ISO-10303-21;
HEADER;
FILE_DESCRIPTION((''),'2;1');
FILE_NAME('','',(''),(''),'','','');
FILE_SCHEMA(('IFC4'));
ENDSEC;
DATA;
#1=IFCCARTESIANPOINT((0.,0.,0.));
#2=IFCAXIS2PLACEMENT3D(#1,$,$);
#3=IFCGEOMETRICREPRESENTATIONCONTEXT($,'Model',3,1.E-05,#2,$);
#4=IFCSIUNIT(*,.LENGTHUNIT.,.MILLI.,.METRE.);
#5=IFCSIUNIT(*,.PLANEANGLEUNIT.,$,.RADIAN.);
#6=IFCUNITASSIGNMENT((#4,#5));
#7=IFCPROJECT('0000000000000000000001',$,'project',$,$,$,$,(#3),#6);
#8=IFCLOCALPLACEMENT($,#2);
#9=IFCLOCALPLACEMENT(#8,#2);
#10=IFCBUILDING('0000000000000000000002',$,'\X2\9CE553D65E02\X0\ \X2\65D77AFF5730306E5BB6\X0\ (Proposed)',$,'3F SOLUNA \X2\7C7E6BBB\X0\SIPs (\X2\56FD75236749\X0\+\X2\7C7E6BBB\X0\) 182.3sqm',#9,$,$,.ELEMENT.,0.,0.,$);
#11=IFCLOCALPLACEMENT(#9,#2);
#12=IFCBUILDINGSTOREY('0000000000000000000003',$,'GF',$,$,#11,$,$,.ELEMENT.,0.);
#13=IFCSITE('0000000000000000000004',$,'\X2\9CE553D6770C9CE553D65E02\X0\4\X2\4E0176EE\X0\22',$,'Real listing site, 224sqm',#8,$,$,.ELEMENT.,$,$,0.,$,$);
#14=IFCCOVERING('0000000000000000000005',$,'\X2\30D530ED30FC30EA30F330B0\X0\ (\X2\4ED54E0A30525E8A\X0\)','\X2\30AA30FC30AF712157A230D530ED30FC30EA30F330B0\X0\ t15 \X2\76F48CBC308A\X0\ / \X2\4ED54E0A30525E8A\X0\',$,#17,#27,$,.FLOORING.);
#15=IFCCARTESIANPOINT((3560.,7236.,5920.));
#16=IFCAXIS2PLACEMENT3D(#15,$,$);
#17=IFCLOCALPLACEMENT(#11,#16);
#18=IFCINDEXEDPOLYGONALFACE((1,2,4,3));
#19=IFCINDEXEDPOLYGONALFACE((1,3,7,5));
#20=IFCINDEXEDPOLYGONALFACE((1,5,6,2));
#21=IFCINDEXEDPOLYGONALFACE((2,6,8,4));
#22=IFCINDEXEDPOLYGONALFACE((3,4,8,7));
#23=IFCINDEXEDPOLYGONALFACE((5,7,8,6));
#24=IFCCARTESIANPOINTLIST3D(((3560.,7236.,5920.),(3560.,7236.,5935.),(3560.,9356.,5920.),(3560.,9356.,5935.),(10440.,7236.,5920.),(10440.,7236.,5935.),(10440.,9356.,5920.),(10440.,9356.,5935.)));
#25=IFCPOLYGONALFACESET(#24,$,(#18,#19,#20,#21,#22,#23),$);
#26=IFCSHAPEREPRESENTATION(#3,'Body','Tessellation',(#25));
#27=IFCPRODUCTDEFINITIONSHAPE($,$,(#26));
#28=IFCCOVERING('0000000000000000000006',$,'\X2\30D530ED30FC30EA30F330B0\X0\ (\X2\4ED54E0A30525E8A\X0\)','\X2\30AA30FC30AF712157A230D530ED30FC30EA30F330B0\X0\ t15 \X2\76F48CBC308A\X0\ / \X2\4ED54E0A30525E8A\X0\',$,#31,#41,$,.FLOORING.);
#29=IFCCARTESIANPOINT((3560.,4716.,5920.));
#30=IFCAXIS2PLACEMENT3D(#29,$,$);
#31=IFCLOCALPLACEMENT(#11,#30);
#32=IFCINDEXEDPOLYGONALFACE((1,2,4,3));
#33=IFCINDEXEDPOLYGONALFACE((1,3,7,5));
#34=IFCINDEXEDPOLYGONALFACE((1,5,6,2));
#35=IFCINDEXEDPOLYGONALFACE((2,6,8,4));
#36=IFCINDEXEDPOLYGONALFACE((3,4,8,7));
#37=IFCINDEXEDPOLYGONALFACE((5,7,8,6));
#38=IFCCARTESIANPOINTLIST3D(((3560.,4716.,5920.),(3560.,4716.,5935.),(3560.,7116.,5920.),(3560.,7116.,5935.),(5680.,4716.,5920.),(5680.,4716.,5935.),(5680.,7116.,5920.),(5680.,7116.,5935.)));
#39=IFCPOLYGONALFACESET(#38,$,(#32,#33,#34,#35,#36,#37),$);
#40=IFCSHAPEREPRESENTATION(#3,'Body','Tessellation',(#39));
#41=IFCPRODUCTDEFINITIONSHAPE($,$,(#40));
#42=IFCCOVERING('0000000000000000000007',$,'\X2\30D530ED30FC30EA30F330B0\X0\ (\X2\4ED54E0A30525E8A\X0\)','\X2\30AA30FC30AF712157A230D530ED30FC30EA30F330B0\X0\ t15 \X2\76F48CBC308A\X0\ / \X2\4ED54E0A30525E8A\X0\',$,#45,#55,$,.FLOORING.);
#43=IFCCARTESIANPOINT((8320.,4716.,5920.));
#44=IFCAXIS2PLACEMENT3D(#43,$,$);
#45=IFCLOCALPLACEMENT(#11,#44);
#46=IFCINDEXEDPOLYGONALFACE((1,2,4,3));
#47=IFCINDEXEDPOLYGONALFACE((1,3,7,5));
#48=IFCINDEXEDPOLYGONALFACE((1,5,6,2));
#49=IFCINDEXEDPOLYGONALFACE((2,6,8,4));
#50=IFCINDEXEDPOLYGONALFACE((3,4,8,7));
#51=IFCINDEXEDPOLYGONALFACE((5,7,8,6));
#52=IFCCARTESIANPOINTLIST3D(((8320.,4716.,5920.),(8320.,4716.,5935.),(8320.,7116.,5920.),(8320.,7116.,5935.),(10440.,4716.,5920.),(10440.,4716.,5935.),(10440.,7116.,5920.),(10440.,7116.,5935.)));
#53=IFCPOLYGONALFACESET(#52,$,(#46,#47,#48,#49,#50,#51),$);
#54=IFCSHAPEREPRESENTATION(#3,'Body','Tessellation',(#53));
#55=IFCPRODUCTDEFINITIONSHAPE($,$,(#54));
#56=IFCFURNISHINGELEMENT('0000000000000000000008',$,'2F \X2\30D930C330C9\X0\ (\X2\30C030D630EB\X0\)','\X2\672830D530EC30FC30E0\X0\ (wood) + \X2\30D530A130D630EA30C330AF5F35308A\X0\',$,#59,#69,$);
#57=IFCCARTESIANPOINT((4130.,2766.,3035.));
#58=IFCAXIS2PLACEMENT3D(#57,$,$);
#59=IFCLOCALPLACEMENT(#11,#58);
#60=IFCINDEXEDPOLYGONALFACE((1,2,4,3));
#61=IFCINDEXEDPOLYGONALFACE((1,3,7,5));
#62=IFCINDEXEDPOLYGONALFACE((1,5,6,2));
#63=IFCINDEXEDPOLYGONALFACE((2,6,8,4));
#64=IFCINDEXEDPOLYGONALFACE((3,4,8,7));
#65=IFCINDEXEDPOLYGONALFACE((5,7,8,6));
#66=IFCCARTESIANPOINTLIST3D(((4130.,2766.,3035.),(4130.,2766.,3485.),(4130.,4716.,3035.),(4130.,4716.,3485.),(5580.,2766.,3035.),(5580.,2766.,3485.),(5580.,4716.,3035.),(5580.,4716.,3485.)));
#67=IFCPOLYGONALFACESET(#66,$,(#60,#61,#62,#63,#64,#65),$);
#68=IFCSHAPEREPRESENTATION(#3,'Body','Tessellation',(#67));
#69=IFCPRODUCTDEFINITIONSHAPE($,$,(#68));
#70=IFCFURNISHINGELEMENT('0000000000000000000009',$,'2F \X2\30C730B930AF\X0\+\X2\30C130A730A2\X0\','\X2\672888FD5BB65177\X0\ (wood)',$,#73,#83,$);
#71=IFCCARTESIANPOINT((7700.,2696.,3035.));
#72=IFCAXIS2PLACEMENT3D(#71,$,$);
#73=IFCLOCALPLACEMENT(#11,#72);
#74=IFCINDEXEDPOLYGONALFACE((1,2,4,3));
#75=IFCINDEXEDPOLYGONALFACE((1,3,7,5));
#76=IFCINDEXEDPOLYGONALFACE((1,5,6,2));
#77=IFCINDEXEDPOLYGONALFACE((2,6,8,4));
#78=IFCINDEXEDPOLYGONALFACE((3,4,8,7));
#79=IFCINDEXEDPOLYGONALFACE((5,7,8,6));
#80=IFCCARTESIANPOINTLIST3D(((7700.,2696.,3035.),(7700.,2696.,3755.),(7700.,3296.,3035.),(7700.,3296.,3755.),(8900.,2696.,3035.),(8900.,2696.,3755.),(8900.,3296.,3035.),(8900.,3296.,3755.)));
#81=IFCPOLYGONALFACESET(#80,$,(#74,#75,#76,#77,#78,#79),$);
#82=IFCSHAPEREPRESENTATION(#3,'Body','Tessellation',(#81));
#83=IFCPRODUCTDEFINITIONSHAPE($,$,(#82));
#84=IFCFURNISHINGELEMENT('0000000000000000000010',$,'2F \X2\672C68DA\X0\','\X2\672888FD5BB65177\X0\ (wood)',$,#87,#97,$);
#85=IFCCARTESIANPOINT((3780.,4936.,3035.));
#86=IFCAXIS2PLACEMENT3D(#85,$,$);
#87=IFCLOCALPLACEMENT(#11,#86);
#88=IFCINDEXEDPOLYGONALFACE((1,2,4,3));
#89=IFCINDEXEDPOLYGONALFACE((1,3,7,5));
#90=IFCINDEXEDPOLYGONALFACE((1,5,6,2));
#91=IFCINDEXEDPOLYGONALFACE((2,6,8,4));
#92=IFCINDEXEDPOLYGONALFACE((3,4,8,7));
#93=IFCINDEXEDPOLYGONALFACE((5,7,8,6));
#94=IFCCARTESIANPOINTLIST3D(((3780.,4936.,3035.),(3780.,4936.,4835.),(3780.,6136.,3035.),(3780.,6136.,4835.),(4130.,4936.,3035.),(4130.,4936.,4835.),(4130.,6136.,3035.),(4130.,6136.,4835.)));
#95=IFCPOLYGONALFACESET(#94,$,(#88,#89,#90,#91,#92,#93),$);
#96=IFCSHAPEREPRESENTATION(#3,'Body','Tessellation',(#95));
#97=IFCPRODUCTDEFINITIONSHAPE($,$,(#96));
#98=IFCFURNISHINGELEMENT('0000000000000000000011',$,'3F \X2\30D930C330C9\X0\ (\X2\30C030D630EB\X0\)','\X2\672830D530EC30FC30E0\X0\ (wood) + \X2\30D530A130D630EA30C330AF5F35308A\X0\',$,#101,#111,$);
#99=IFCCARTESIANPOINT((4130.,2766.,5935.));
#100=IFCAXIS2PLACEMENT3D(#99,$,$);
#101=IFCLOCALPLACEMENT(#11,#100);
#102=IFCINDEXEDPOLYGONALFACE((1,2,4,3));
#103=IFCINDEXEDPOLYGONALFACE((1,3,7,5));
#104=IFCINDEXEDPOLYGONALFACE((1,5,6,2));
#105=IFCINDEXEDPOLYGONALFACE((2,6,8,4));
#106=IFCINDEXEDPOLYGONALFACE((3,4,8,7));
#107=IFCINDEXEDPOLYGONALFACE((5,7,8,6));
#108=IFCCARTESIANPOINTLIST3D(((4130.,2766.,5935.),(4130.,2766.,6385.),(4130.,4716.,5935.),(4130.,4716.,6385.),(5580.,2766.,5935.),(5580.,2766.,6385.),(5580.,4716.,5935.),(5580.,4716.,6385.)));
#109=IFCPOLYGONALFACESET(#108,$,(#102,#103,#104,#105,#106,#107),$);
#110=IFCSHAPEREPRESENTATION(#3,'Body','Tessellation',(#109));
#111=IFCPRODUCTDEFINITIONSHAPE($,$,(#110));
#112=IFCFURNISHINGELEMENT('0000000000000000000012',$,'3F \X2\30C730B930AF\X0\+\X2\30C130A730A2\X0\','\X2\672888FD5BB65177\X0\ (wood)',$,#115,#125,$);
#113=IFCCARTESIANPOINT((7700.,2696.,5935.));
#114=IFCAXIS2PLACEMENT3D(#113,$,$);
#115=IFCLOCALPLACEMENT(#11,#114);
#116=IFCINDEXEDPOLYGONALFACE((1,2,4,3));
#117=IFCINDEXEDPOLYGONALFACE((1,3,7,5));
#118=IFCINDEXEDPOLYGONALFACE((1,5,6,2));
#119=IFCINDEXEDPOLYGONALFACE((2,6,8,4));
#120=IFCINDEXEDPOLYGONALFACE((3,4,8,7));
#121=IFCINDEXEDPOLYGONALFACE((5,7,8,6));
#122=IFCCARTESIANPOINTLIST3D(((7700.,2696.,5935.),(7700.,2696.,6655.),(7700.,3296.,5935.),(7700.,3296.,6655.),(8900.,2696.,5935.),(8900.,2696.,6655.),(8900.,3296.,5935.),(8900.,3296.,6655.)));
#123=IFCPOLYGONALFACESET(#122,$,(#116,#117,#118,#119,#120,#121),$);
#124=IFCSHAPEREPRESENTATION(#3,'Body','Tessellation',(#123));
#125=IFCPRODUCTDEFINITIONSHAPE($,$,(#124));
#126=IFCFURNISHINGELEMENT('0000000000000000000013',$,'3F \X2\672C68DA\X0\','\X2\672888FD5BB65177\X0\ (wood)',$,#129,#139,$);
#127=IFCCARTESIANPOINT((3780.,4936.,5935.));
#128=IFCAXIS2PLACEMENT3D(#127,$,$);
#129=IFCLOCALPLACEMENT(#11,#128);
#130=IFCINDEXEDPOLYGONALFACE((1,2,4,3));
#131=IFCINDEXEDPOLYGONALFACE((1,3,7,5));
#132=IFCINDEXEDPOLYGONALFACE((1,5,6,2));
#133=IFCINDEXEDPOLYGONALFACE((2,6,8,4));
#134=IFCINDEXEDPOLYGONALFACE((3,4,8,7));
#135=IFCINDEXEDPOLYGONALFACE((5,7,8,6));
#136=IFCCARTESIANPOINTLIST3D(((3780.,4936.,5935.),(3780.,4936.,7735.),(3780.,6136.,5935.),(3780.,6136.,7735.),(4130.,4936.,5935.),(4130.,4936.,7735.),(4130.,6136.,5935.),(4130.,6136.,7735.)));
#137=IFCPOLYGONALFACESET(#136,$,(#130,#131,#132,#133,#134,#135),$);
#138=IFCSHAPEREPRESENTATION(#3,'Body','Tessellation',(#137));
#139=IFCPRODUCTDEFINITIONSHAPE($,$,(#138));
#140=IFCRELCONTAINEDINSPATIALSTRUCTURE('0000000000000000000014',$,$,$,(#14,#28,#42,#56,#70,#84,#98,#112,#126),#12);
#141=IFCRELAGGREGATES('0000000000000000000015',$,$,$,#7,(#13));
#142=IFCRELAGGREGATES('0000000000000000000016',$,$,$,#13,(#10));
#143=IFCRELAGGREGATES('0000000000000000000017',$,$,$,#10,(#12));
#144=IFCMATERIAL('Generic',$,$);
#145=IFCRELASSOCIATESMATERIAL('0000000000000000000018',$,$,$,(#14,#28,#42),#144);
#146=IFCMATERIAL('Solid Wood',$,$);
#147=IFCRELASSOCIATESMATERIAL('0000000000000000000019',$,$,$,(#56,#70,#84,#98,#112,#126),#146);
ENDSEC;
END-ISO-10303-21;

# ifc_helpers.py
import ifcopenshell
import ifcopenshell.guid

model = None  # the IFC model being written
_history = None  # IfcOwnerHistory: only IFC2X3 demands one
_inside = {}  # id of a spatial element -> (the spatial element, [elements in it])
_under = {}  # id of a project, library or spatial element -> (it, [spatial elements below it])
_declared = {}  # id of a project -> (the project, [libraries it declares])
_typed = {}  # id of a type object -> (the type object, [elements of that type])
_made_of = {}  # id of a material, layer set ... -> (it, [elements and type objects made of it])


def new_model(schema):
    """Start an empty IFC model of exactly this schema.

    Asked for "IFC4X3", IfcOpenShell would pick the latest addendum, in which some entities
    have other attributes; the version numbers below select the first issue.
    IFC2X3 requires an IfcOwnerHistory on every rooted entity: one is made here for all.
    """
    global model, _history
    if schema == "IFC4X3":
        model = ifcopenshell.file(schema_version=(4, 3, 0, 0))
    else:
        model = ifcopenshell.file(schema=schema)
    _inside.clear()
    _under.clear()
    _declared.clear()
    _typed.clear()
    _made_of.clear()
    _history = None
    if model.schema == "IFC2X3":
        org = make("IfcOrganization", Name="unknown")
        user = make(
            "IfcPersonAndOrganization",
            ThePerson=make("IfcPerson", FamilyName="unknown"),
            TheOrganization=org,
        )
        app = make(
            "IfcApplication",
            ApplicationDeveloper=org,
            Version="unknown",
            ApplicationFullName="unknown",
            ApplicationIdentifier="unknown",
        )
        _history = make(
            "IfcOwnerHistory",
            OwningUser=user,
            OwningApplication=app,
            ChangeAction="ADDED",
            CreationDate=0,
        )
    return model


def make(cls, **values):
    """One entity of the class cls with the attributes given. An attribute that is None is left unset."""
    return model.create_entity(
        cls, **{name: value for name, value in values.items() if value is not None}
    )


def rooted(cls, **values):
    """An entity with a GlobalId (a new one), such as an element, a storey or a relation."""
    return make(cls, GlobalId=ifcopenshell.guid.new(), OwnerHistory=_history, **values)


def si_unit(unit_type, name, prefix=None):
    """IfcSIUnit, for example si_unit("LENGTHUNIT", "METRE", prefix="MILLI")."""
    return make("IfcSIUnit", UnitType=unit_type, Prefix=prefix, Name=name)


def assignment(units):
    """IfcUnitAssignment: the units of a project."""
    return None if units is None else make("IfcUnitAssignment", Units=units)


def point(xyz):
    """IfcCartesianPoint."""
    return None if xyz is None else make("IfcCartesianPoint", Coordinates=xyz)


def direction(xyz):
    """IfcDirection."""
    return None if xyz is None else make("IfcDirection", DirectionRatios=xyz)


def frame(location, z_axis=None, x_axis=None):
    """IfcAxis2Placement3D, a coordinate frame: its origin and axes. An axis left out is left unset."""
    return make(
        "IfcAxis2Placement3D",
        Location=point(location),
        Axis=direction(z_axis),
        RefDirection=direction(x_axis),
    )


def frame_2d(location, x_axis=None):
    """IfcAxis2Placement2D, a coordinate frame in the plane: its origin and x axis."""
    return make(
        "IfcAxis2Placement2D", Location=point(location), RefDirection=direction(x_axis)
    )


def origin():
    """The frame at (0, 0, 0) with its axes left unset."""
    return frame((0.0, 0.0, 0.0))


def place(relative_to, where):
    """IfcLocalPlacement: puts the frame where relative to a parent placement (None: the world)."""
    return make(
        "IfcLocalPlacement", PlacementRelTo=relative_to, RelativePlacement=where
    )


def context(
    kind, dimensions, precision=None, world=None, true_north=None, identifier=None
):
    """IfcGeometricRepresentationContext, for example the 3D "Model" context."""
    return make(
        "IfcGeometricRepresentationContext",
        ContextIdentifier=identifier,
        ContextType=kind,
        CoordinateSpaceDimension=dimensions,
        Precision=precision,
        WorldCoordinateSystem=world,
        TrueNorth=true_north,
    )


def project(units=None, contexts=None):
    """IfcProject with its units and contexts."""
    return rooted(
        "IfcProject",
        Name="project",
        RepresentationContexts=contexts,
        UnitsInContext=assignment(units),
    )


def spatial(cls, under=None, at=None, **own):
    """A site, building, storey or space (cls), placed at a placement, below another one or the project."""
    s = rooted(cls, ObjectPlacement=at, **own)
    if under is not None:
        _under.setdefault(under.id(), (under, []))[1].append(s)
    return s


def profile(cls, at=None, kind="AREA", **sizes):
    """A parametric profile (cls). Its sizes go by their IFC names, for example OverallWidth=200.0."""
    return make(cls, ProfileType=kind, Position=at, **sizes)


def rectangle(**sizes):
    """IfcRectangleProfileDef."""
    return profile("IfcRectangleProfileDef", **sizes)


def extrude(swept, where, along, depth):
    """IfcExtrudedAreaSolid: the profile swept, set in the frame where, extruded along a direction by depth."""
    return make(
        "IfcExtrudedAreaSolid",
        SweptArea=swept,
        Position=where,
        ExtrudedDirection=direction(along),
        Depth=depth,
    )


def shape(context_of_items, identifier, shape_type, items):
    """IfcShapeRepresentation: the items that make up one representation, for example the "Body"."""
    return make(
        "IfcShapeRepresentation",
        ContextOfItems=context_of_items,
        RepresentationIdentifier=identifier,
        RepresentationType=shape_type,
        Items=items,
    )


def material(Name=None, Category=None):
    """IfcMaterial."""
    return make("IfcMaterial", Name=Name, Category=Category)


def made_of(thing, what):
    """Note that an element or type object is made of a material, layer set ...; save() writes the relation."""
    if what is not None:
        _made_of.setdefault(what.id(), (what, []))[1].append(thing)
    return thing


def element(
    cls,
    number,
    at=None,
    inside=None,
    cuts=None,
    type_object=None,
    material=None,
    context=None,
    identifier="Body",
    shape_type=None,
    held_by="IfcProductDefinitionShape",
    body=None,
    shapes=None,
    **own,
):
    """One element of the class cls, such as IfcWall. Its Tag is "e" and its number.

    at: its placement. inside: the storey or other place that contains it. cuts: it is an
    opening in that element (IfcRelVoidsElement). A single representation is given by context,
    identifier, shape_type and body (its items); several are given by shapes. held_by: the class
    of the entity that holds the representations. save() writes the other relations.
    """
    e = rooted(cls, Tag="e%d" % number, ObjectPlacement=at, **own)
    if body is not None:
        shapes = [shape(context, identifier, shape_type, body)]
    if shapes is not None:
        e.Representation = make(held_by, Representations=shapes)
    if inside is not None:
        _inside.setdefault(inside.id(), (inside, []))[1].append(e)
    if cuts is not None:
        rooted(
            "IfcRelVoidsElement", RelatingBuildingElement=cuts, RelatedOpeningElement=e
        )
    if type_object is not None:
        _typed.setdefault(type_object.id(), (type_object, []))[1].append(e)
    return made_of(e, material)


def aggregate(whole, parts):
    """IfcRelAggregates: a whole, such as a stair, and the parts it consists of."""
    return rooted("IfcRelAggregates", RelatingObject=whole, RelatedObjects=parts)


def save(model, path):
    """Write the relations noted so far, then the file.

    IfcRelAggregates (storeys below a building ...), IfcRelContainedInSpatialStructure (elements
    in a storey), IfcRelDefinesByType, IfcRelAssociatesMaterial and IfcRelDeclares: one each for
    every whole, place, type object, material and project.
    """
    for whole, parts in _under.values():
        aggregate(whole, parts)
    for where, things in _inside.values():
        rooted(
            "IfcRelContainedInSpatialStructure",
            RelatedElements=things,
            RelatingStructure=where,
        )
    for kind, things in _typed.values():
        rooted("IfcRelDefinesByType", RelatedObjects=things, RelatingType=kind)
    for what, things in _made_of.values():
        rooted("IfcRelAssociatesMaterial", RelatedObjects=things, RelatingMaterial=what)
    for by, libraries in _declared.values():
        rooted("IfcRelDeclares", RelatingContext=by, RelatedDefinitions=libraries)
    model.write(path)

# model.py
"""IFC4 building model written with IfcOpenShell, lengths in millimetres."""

from ifc_helpers import new_model, si_unit, frame, frame_2d, origin, place, context, project, spatial, rectangle, extrude, material, element, save


model = new_model("IFC4")

# Units and contexts
model_context = context("Model", 3, precision=1e-05, world=origin())
ifc_project = project(units=[si_unit("LENGTHUNIT", "METRE", prefix="MILLI"), si_unit("PLANEANGLEUNIT", "RADIAN")], contexts=[model_context])

# Site, building, storey
site_placement = place(None, origin())
site = spatial("IfcSite", under=ifc_project, at=site_placement, Name="鳥取県鳥取市4丁目22", ObjectType="Real listing site, 224sqm", CompositionType="ELEMENT", RefElevation=0.0)
building_placement = place(site_placement, origin())
building = spatial("IfcBuilding", under=site, at=building_placement, Name="鳥取市 旗竿地の家 (Proposed)", ObjectType="3F SOLUNA 籾殻SIPs (国産杉+籾殻) 182.3sqm", CompositionType="ELEMENT", ElevationOfRefHeight=0.0, ElevationOfTerrain=0.0)
storey_placement = place(building_placement, origin())
storey = spatial("IfcBuildingStorey", under=building, at=storey_placement, Name="GF", CompositionType="ELEMENT", Elevation=0.0)

# Shared definitions
ifc_material_1 = material(Name="Solid Wood")

# Shared definitions
ifc_material_2 = material(Name="Generic")

# Coverings
covering_1_placement = place(storey_placement, frame((3560.0, 7236.0, 5920.0)))
element("IfcCovering", 1, at=covering_1_placement, inside=storey, material=ifc_material_2, Name="フローリング (仕上げ床)", Description="オーク無垢フローリング t15 直貼り / 仕上げ床", PredefinedType="FLOORING", context=model_context, shape_type="SweptSolid", body=[
    extrude(rectangle(XDim=6880.0, YDim=2120.0, at=frame_2d((3440.0, 1060.0))), frame((3560.0, 7236.0, 5920.0)), (0.0, 0.0, 1.0), 15.0),
])
covering_2_placement = place(storey_placement, frame((3560.0, 4716.0, 5920.0)))
element("IfcCovering", 2, at=covering_2_placement, inside=storey, material=ifc_material_2, Name="フローリング (仕上げ床)", Description="オーク無垢フローリング t15 直貼り / 仕上げ床", PredefinedType="FLOORING", context=model_context, shape_type="SweptSolid", body=[
    extrude(rectangle(XDim=2120.0, YDim=2400.0, at=frame_2d((1060.0, 1200.0))), frame((3560.0, 4716.0, 5920.0)), (0.0, 0.0, 1.0), 15.0),
])
covering_3_placement = place(storey_placement, frame((8320.0, 4716.0, 5920.0)))
element("IfcCovering", 3, at=covering_3_placement, inside=storey, material=ifc_material_2, Name="フローリング (仕上げ床)", Description="オーク無垢フローリング t15 直貼り / 仕上げ床", PredefinedType="FLOORING", context=model_context, shape_type="SweptSolid", body=[
    extrude(rectangle(XDim=2120.0, YDim=2400.0, at=frame_2d((1060.0, 1200.0))), frame((8320.0, 4716.0, 5920.0)), (0.0, 0.0, 1.0), 15.0),
])

# Furnishing elements
furnishing_1_placement = place(storey_placement, frame((4130.0, 2766.0, 3035.0)))
element("IfcFurnishingElement", 4, at=furnishing_1_placement, inside=storey, material=ifc_material_1, Name="2F ベッド (ダブル)", Description="木フレーム (wood) + ファブリック張り", context=model_context, shape_type="SweptSolid", body=[
    extrude(rectangle(XDim=1450.0, YDim=1950.0, at=frame_2d((725.0, 975.0))), frame((4130.0, 2766.0, 3035.0)), (0.0, 0.0, 1.0), 450.0),
])
furnishing_2_placement = place(storey_placement, frame((7700.0, 2696.0, 3035.0)))
element("IfcFurnishingElement", 5, at=furnishing_2_placement, inside=storey, material=ifc_material_1, Name="2F デスク+チェア", Description="木製家具 (wood)", context=model_context, shape_type="SweptSolid", body=[
    extrude(rectangle(XDim=1200.0, YDim=600.0, at=frame_2d((600.0, 300.0))), frame((7700.0, 2696.0, 3035.0)), (0.0, 0.0, 1.0), 720.0),
])
furnishing_3_placement = place(storey_placement, frame((3780.0, 4936.0, 3035.0)))
element("IfcFurnishingElement", 6, at=furnishing_3_placement, inside=storey, material=ifc_material_1, Name="2F 本棚", Description="木製家具 (wood)", context=model_context, shape_type="SweptSolid", body=[
    extrude(rectangle(XDim=350.0, YDim=1200.0, at=frame_2d((175.0, 600.0))), frame((3780.0, 4936.0, 3035.0)), (0.0, 0.0, 1.0), 1800.0),
])
furnishing_4_placement = place(storey_placement, frame((4130.0, 2766.0, 5935.0)))
element("IfcFurnishingElement", 7, at=furnishing_4_placement, inside=storey, material=ifc_material_1, Name="3F ベッド (ダブル)", Description="木フレーム (wood) + ファブリック張り", context=model_context, shape_type="SweptSolid", body=[
    extrude(rectangle(XDim=1450.0, YDim=1950.0, at=frame_2d((725.0, 975.0))), frame((4130.0, 2766.0, 5935.0)), (0.0, 0.0, 1.0), 450.0),
])
furnishing_5_placement = place(storey_placement, frame((7700.0, 2696.0, 5935.0)))
element("IfcFurnishingElement", 8, at=furnishing_5_placement, inside=storey, material=ifc_material_1, Name="3F デスク+チェア", Description="木製家具 (wood)", context=model_context, shape_type="SweptSolid", body=[
    extrude(rectangle(XDim=1200.0, YDim=600.0, at=frame_2d((600.0, 300.0))), frame((7700.0, 2696.0, 5935.0)), (0.0, 0.0, 1.0), 720.0),
])
furnishing_6_placement = place(storey_placement, frame((3780.0, 4936.0, 5935.0)))
element("IfcFurnishingElement", 9, at=furnishing_6_placement, inside=storey, material=ifc_material_1, Name="3F 本棚", Description="木製家具 (wood)", context=model_context, shape_type="SweptSolid", body=[
    extrude(rectangle(XDim=350.0, YDim=1200.0, at=frame_2d((175.0, 600.0))), frame((3780.0, 4936.0, 5935.0)), (0.0, 0.0, 1.0), 1800.0),
])

save(model, "model.ifc")
